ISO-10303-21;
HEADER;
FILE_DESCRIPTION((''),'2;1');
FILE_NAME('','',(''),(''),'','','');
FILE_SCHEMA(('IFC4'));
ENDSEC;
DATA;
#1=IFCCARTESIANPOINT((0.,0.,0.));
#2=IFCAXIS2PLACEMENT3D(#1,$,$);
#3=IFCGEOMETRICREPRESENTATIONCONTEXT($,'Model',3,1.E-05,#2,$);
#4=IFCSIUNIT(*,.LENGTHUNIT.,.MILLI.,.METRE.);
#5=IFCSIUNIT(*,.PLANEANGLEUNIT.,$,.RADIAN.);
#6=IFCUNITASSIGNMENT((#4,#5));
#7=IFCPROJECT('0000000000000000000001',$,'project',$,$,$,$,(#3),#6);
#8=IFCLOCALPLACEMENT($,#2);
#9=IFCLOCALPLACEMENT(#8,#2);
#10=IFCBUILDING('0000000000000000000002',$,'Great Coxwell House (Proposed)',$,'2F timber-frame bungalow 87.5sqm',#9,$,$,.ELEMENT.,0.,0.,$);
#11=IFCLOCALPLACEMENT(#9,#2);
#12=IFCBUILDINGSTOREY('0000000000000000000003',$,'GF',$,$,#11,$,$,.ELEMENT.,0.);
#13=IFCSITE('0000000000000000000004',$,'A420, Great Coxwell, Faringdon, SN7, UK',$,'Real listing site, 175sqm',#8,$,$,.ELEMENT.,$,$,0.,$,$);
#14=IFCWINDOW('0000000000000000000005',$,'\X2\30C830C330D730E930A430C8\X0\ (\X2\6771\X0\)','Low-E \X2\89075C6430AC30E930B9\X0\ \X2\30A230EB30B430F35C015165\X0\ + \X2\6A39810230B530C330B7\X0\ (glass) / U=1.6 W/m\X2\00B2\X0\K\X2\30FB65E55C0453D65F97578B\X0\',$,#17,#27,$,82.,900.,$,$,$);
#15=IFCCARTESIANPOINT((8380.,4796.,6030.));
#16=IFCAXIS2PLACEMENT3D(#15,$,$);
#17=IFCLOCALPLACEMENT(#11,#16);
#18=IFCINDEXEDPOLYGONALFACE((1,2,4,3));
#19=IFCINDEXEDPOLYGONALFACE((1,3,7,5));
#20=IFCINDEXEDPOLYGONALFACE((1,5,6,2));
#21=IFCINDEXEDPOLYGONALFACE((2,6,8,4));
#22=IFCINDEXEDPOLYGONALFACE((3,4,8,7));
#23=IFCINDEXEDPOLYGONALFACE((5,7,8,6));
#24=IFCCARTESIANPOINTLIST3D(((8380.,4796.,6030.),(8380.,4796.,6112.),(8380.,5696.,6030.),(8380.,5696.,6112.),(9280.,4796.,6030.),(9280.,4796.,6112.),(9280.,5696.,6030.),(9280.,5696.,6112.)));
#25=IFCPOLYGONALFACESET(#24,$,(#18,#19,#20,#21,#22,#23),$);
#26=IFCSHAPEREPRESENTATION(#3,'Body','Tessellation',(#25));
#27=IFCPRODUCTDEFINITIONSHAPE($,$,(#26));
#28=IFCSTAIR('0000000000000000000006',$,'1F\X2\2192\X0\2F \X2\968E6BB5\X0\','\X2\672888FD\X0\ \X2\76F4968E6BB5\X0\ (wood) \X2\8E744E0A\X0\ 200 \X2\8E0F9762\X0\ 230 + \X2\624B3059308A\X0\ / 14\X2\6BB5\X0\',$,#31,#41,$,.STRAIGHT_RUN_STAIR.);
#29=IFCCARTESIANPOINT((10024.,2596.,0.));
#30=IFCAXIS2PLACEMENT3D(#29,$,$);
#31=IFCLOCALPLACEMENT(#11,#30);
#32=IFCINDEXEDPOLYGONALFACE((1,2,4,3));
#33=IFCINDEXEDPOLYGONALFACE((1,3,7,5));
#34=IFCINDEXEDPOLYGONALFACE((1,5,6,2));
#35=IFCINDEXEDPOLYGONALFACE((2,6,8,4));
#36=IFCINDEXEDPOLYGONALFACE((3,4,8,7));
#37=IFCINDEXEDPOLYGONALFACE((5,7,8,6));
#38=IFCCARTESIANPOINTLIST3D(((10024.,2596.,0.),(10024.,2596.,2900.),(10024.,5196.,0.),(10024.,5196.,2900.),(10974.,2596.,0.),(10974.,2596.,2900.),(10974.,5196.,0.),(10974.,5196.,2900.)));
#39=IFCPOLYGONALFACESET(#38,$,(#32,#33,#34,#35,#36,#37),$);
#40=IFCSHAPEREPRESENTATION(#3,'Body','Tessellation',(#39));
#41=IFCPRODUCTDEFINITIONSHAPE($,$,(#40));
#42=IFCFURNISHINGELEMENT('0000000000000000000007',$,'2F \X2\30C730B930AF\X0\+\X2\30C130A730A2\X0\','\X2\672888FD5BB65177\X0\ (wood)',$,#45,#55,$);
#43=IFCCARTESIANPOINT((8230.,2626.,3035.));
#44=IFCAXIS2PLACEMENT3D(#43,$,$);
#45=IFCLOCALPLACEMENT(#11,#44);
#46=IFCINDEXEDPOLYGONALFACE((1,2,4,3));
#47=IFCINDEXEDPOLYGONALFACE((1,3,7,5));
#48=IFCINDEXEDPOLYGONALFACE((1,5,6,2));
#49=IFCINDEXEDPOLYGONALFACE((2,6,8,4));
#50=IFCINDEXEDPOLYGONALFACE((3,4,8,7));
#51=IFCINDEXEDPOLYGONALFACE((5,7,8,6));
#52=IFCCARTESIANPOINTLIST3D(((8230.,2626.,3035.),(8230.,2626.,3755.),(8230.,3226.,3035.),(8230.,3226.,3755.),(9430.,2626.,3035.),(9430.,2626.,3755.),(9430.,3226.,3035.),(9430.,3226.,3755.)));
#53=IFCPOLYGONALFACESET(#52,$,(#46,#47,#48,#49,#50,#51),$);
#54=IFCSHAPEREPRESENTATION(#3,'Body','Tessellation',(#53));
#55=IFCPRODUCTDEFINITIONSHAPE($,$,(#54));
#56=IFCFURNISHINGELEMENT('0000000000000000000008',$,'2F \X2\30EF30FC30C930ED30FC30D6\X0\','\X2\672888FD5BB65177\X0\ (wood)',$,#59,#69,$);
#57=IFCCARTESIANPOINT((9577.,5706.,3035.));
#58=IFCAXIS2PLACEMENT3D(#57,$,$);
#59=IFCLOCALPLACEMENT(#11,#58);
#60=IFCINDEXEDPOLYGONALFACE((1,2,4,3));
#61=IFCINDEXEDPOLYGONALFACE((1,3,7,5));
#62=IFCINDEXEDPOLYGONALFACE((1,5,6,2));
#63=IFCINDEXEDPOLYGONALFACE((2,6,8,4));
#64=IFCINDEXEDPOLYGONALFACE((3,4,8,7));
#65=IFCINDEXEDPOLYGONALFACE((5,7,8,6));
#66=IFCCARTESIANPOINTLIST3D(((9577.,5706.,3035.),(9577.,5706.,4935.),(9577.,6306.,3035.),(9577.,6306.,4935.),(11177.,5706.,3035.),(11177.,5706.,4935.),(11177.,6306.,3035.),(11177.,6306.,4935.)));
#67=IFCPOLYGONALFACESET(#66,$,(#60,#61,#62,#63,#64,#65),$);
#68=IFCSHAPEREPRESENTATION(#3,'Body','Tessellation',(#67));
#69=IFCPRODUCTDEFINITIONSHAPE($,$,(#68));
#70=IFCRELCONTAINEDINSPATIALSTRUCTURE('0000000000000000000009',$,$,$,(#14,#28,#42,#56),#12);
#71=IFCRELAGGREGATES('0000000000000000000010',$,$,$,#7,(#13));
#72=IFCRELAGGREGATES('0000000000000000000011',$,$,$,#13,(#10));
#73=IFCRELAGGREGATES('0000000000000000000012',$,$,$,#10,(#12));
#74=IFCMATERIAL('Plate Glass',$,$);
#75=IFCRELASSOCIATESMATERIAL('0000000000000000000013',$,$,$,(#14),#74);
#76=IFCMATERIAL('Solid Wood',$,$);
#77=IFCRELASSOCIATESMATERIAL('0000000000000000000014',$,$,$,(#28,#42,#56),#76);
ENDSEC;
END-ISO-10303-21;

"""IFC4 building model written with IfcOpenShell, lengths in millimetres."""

from ifc_helpers import new_model, si_unit, frame, frame_2d, origin, place, context, project, spatial, rectangle, extrude, material, element, save


model = new_model("IFC4")

# Units and contexts
model_context = context("Model", 3, precision=1e-05, world=origin())
ifc_project = project(units=[si_unit("LENGTHUNIT", "METRE", prefix="MILLI"), si_unit("PLANEANGLEUNIT", "RADIAN")], contexts=[model_context])

# Site, building, storey
site_placement = place(None, origin())
site = spatial("IfcSite", under=ifc_project, at=site_placement, Name="A420, Great Coxwell, Faringdon, SN7, UK", ObjectType="Real listing site, 175sqm", CompositionType="ELEMENT", RefElevation=0.0)
building_placement = place(site_placement, origin())
building = spatial("IfcBuilding", under=site, at=building_placement, Name="Great Coxwell House (Proposed)", ObjectType="2F timber-frame bungalow 87.5sqm", CompositionType="ELEMENT", ElevationOfRefHeight=0.0, ElevationOfTerrain=0.0)
storey_placement = place(building_placement, origin())
storey = spatial("IfcBuildingStorey", under=building, at=storey_placement, Name="GF", CompositionType="ELEMENT", Elevation=0.0)

# Shared definitions
ifc_material_1 = material(Name="Solid Wood")

# Shared definitions
ifc_material_2 = material(Name="Plate Glass")

# Window
window_1_placement = place(storey_placement, frame((8380.0, 4796.0, 6030.0)))
element("IfcWindow", 1, at=window_1_placement, inside=storey, material=ifc_material_2, Name="トップライト (東)", Description="Low-E 複層ガラス アルゴン封入 + 樹脂サッシ (glass) / U=1.6 W/m²K・日射取得型", OverallHeight=82.0, OverallWidth=900.0, context=model_context, shape_type="SweptSolid", body=[
    extrude(rectangle(XDim=900.0, YDim=900.0, at=frame_2d((450.0, 450.0))), frame((8380.0, 4796.0, 6030.0)), (0.0, 0.0, 1.0), 82.0),
])

# Stair
stair_placement = place(storey_placement, frame((10024.0, 2596.0, 0.0)))
element("IfcStair", 2, at=stair_placement, inside=storey, material=ifc_material_1, Name="1F→2F 階段", Description="木製 直階段 (wood) 蹴上 200 踏面 230 + 手すり / 14段", PredefinedType="STRAIGHT_RUN_STAIR", context=model_context, shape_type="SweptSolid", body=[
    extrude(rectangle(XDim=950.0, YDim=2600.0, at=frame_2d((475.0, 1300.0))), frame((10024.0, 2596.0, 0.0)), (0.0, 0.0, 1.0), 2900.0),
])

# Furnishing elements
furnishing_1_placement = place(storey_placement, frame((8230.0, 2626.0, 3035.0)))
element("IfcFurnishingElement", 3, at=furnishing_1_placement, inside=storey, material=ifc_material_1, Name="2F デスク+チェア", Description="木製家具 (wood)", context=model_context, shape_type="SweptSolid", body=[
    extrude(rectangle(XDim=1200.0, YDim=600.0, at=frame_2d((600.0, 300.0))), frame((8230.0, 2626.0, 3035.0)), (0.0, 0.0, 1.0), 720.0),
])
furnishing_2_placement = place(storey_placement, frame((9577.0, 5706.0, 3035.0)))
element("IfcFurnishingElement", 4, at=furnishing_2_placement, inside=storey, material=ifc_material_1, Name="2F ワードローブ", Description="木製家具 (wood)", context=model_context, shape_type="SweptSolid", body=[
    extrude(rectangle(XDim=1600.0, YDim=600.0, at=frame_2d((800.0, 300.0))), frame((9577.0, 5706.0, 3035.0)), (0.0, 0.0, 1.0), 1900.0),
])

save(model, "model.ifc")
